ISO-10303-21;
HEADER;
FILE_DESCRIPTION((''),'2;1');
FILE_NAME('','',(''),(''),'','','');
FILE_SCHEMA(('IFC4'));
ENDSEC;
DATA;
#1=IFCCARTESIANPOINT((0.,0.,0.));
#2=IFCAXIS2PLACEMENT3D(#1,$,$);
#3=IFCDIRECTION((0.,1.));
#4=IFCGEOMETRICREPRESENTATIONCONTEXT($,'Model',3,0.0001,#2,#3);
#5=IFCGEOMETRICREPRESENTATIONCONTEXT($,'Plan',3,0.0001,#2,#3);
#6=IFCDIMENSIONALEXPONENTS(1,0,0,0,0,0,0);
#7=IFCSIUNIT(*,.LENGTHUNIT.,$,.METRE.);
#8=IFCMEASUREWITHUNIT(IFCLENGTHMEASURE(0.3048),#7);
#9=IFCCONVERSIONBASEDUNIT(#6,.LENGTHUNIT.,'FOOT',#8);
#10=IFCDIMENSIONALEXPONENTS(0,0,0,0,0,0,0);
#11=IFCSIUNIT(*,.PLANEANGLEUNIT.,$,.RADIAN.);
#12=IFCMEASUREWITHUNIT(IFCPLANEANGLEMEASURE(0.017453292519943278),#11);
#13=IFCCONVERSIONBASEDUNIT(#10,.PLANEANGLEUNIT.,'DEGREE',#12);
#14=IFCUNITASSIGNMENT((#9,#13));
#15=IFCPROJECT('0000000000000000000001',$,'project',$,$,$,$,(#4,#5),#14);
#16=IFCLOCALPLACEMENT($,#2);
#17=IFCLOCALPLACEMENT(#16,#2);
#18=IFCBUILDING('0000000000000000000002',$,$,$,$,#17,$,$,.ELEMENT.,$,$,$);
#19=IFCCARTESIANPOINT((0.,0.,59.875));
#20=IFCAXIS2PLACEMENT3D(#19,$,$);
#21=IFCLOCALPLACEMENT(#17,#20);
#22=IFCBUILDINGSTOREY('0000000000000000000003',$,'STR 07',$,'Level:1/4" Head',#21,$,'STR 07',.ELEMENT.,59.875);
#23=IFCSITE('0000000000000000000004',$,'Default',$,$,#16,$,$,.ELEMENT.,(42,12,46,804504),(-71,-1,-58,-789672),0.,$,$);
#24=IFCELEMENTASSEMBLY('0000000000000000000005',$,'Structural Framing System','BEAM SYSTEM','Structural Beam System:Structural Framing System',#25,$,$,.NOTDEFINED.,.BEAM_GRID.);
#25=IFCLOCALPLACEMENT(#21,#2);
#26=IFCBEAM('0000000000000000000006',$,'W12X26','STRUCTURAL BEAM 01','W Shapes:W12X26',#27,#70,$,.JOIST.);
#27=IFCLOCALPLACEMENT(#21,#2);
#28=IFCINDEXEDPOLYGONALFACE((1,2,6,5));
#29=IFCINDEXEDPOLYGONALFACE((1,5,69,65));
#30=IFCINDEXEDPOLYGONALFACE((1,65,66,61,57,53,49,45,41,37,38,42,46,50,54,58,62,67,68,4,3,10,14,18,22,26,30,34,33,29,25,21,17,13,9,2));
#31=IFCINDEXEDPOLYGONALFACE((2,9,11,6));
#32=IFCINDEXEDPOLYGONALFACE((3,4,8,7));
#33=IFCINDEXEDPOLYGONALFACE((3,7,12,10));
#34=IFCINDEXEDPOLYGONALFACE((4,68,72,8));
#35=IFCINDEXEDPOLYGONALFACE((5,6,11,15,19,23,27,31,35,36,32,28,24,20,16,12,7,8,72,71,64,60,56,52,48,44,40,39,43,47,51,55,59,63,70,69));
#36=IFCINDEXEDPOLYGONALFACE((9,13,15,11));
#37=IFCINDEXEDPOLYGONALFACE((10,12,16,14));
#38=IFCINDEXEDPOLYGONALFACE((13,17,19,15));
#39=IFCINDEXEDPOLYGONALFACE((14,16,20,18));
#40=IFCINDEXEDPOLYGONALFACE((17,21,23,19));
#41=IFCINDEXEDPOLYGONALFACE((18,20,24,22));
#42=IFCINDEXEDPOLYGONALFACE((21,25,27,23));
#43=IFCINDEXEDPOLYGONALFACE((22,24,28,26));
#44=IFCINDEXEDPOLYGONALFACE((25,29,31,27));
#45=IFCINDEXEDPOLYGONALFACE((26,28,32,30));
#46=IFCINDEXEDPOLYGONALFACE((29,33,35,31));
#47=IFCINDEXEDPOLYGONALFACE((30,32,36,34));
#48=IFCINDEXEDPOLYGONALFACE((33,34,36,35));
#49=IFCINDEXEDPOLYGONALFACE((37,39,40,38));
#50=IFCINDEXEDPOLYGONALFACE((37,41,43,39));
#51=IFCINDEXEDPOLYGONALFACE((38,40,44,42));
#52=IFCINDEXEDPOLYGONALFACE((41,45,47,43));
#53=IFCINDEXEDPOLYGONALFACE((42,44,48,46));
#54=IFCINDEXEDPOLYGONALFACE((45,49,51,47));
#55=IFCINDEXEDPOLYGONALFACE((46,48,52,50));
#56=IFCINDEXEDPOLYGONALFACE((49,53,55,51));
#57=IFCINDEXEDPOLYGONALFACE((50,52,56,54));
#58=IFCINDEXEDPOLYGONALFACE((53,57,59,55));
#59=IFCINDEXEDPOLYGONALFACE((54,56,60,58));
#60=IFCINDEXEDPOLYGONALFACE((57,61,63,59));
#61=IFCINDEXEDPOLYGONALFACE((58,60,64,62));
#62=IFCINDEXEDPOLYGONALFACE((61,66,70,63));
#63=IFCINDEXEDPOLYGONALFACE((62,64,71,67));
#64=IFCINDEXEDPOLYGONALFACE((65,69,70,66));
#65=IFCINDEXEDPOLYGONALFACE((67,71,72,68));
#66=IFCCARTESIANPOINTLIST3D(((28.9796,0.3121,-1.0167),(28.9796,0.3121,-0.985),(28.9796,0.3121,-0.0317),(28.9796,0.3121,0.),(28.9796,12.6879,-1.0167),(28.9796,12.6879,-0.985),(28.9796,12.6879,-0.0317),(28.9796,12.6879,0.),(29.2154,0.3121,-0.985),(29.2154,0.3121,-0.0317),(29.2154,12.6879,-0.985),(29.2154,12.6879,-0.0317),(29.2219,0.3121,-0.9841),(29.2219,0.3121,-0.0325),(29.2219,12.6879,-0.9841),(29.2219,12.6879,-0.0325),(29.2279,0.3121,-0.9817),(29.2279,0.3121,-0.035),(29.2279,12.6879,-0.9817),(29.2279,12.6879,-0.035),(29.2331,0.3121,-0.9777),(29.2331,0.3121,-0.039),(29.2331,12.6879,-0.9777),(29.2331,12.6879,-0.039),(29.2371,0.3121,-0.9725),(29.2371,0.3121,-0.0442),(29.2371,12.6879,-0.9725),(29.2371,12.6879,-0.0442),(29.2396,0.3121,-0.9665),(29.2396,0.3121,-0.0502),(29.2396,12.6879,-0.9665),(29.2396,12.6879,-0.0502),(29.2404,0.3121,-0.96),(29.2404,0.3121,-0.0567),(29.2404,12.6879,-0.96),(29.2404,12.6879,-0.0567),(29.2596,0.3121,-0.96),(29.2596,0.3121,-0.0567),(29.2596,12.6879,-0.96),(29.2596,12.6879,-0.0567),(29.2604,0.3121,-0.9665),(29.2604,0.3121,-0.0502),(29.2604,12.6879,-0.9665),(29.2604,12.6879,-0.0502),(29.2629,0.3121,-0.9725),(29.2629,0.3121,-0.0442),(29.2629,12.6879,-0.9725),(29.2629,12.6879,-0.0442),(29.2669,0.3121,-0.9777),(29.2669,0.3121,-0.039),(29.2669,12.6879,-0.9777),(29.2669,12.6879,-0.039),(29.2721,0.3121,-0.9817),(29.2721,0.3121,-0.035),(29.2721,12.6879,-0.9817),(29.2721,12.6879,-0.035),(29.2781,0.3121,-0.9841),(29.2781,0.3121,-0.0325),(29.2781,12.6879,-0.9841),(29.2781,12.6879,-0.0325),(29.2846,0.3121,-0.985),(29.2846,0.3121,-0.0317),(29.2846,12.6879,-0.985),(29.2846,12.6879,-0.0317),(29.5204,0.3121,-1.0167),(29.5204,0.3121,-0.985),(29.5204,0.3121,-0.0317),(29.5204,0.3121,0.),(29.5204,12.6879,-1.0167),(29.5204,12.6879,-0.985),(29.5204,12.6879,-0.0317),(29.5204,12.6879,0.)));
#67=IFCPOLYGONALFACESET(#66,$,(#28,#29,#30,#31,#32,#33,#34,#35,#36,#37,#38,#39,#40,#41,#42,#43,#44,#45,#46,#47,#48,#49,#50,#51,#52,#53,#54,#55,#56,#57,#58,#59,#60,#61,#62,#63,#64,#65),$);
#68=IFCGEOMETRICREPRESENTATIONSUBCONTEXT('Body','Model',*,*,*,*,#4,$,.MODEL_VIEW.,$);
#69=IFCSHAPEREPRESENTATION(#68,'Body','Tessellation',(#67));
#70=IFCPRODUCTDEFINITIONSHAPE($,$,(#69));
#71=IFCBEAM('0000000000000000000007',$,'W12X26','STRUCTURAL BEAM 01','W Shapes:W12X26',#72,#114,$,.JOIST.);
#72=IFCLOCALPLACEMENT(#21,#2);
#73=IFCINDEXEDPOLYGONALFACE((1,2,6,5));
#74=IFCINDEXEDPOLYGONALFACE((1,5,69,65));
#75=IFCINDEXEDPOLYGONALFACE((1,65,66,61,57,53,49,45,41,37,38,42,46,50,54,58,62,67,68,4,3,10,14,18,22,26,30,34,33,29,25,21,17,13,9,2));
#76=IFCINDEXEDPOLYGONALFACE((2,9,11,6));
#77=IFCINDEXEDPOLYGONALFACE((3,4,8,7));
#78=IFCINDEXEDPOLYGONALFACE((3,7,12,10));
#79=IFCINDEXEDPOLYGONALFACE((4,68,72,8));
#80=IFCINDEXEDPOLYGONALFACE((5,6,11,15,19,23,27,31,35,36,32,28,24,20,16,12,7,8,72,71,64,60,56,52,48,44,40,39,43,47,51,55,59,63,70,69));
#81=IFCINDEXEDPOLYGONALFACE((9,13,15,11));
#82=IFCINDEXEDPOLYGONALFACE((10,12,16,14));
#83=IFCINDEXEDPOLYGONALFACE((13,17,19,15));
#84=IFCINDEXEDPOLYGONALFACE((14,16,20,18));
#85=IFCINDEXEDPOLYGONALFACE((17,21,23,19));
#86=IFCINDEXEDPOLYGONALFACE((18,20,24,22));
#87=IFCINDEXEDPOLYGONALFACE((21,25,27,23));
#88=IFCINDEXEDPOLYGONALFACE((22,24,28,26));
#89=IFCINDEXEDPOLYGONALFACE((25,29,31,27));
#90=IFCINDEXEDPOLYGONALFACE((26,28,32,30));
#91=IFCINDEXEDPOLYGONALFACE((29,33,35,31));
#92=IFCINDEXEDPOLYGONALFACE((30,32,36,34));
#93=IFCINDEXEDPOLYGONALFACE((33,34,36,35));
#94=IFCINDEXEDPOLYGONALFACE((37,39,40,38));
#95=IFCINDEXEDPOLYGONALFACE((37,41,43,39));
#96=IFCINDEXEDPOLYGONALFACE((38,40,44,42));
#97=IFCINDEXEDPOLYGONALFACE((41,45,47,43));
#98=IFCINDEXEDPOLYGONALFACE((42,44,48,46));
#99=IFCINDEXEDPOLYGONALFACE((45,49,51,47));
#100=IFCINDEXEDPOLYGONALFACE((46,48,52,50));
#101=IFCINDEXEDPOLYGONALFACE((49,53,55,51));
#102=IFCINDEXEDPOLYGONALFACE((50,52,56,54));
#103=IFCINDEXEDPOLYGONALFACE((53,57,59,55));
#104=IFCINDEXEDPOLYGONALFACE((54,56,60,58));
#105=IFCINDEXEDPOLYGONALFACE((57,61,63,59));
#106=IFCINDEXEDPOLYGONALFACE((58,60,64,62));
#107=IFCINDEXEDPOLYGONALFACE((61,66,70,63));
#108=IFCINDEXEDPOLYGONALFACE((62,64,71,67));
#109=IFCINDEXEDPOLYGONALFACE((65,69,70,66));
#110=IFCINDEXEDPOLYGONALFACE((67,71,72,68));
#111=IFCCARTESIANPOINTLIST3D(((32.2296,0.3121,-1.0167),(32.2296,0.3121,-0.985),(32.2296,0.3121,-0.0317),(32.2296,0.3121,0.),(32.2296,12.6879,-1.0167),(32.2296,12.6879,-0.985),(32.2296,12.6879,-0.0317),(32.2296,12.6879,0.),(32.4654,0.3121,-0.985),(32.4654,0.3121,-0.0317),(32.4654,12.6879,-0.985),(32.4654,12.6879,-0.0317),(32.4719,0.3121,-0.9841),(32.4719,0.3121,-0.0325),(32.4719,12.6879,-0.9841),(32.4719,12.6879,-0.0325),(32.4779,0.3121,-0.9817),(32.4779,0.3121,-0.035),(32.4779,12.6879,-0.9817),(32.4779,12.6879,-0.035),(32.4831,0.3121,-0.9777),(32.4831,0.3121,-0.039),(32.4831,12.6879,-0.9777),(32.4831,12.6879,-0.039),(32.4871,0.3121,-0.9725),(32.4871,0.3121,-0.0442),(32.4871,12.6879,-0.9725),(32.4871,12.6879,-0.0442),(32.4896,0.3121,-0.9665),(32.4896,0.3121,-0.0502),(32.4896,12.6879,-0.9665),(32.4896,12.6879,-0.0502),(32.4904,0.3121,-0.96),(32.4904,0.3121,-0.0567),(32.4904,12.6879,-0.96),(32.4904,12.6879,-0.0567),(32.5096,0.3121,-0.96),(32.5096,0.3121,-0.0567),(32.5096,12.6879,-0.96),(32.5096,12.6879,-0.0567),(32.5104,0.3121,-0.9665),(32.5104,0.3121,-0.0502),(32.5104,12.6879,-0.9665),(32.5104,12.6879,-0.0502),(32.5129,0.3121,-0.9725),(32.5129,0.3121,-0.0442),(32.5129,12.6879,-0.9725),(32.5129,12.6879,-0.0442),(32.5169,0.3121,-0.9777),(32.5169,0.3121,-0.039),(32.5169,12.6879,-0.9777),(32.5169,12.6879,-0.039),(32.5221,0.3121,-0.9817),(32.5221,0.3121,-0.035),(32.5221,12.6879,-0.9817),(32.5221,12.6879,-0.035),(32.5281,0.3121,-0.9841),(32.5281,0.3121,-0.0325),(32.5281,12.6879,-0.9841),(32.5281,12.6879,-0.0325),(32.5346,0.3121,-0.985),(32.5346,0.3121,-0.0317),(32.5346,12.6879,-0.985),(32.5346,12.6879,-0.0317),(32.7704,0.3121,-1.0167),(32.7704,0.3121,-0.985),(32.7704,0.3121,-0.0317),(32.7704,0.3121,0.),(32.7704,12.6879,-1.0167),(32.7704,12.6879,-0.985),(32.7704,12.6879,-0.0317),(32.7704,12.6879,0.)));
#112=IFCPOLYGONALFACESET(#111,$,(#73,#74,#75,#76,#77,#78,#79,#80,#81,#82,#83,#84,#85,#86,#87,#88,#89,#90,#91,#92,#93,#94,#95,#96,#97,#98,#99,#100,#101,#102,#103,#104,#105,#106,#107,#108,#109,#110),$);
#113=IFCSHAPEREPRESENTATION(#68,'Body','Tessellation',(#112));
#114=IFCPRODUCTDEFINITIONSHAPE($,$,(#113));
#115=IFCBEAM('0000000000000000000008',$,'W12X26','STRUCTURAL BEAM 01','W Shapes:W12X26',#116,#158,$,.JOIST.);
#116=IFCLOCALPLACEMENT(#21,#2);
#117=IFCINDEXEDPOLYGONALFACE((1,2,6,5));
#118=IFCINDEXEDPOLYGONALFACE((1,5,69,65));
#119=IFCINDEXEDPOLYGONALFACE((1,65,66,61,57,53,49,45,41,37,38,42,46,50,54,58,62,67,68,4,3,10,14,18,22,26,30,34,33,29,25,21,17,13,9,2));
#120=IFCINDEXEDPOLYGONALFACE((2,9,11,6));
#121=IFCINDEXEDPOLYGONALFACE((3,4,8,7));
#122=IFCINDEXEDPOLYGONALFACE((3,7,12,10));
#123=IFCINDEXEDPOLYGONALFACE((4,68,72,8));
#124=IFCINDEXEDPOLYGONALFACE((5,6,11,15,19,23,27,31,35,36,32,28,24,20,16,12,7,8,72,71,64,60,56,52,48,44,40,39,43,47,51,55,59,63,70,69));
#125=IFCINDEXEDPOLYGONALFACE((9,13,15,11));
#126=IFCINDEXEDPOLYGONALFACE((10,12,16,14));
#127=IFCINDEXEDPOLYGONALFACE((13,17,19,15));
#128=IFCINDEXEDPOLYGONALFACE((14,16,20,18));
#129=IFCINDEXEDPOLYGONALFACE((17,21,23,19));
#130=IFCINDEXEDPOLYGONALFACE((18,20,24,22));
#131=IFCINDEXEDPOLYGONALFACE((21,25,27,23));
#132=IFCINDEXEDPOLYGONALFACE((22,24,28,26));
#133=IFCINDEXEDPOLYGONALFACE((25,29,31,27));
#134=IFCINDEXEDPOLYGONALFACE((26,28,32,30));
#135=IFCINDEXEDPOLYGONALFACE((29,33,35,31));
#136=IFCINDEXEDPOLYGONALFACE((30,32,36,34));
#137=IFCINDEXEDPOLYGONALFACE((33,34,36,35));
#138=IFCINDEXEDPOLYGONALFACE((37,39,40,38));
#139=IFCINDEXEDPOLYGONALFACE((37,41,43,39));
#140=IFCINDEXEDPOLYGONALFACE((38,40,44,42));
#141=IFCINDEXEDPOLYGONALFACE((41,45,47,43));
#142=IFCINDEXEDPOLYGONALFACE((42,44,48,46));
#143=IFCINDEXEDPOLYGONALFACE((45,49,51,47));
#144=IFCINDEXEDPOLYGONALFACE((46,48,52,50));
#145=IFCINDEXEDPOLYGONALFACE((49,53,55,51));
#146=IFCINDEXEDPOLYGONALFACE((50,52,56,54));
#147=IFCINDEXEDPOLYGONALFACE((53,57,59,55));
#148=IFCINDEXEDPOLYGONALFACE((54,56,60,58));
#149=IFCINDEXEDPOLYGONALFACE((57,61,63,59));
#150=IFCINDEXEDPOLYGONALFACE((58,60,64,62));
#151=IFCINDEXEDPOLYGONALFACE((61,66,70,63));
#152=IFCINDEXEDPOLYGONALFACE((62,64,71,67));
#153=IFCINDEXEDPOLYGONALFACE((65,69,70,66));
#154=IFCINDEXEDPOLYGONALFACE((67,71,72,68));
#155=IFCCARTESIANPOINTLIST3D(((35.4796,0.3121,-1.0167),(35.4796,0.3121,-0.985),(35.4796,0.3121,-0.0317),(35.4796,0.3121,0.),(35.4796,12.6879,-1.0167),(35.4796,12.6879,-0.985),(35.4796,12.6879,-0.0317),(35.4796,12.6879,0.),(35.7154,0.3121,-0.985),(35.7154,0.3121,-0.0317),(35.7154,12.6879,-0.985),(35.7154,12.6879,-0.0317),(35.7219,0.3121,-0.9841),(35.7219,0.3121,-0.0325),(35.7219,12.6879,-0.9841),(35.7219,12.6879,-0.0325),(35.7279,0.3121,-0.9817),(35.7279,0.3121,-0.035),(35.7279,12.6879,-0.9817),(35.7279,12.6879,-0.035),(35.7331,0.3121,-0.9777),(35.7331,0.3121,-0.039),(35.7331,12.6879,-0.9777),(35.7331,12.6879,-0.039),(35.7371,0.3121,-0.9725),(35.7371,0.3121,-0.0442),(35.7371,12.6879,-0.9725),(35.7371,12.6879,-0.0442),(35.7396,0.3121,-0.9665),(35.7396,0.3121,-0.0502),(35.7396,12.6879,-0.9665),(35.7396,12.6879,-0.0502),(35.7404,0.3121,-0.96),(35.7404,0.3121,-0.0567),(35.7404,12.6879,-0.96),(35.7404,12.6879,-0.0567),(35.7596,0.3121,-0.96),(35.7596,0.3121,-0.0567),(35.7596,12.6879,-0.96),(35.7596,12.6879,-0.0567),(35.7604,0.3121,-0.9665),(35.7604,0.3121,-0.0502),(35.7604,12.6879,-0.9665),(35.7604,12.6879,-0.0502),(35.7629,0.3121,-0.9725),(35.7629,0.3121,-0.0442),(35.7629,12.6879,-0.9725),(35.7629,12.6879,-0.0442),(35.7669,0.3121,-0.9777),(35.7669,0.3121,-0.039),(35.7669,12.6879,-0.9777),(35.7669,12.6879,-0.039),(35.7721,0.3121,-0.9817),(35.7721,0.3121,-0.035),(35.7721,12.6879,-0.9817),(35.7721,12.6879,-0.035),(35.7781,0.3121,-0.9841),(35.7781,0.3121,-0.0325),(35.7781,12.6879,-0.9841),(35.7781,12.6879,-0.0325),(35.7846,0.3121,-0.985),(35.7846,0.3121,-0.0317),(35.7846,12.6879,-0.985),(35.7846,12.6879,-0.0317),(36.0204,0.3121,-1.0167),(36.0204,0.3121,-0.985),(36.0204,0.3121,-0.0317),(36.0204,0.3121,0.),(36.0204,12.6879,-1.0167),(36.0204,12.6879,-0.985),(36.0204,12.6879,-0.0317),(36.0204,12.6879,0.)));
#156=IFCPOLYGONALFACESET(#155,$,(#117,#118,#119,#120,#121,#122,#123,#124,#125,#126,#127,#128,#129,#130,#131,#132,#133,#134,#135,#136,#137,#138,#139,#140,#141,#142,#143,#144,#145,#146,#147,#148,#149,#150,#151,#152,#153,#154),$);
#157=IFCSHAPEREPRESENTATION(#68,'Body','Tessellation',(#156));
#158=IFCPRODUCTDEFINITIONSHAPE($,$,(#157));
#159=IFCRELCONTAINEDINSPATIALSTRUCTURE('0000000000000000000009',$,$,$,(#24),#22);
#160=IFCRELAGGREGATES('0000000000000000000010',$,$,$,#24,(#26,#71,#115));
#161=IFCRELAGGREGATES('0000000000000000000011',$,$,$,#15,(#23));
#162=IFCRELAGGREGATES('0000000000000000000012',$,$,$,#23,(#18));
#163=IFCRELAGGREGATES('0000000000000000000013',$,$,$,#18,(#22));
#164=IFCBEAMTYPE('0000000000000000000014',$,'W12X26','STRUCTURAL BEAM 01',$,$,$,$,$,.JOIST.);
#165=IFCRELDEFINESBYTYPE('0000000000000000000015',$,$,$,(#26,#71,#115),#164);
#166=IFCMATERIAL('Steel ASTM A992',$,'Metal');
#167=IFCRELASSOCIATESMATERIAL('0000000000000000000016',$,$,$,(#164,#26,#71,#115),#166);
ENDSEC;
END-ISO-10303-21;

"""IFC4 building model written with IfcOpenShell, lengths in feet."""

from ifc_helpers import new_model, entity, si_unit, converted_unit, direction, frame, origin, place, context, subcontext, project, spatial, line, arc, indexed_curve, outline, extrude, source, transform, mapped, material, type_object, type_shapes, element, aggregate, save


model = new_model("IFC4")

# Units and contexts
model_context = context("Model", 3, precision=0.0001, world=origin(), true_north=direction((0.0, 1.0)))
plan_context = context("Plan", 3, precision=0.0001, world=origin(), true_north=direction((0.0, 1.0)))
body_context = subcontext(model_context, "Body", "Model", "MODEL_VIEW")
ifc_project = project(units=[converted_unit("LENGTHUNIT", "FOOT", entity("IfcLengthMeasure", 0.3048), si_unit("LENGTHUNIT", "METRE"), dimensions=[1, 0, 0, 0, 0, 0, 0]), converted_unit("PLANEANGLEUNIT", "DEGREE", entity("IfcPlaneAngleMeasure", 0.017453292519943278), si_unit("PLANEANGLEUNIT", "RADIAN"), dimensions=[0, 0, 0, 0, 0, 0, 0])], contexts=[model_context, plan_context])

# Site, building, storey
site_placement = place(None, origin())
site = spatial("IfcSite", under=ifc_project, at=site_placement, Name="Default", CompositionType="ELEMENT", RefLatitude=(42, 12, 46, 804504), RefLongitude=(-71, -1, -58, -789672), RefElevation=0.0)
building_placement = place(site_placement, origin())
building = spatial("IfcBuilding", under=site, at=building_placement, CompositionType="ELEMENT")
storey_placement = place(building_placement, frame((0.0, 0.0, 59.875)))
storey = spatial("IfcBuildingStorey", under=building, at=storey_placement, Name="STR 07", ObjectType="Level:1/4\" Head", LongName="STR 07", CompositionType="ELEMENT", Elevation=59.875)

# Element assembly, beams
ifc_material = material(Name="Steel ASTM A992", Category="Metal")
beam_type_1 = type_object("IfcBeamType", Name="W12X26", Description="STRUCTURAL BEAM 01", PredefinedType="JOIST", material=ifc_material)
shared_shape = source(origin(), body_context, "Body", "SweptSolid", [
    extrude(outline(indexed_curve([(-0.2704, -0.4767), (-0.2704, -0.5083), (0.2704, -0.5083), (0.2704, -0.4767), (0.0346, -0.4767), (0.0169, -0.4693), (0.0096, -0.4517), (0.0096, 0.4517), (0.0169, 0.4693), (0.0346, 0.4767), (0.2704, 0.4767), (0.2704, 0.5083), (-0.2704, 0.5083), (-0.2704, 0.4767), (-0.0346, 0.4767), (-0.0169, 0.4693), (-0.0096, 0.4517), (-0.0096, -0.4517), (-0.0169, -0.4693), (-0.0346, -0.4767)], segments=[line(1, 2, 3, 4, 5), arc(5, 6, 7), line(7, 8), arc(8, 9, 10), line(10, 11, 12, 13, 14, 15), arc(15, 16, 17), line(17, 18), arc(18, 19, 20), line(20, 1)], self_intersect=False)), frame((-6.1879, 0.0, 0.0), z_axis=(-1.0, 0.0, 0.0), x_axis=(0.0, -1.0, 0.0)), (0.0, 0.0, -1.0), 12.3758),
])
type_shapes(beam_type_1, [shared_shape])
assembly_1_placement = place(storey_placement, origin())
assembly_1 = element("IfcElementAssembly", 1, at=assembly_1_placement, inside=storey, Name="Structural Framing System", Description="BEAM SYSTEM", ObjectType="Structural Beam System:Structural Framing System", AssemblyPlace="NOTDEFINED", PredefinedType="BEAM_GRID")
beam_1_placement = place(assembly_1_placement, frame((29.25, 6.5, -0.5083), z_axis=(0.0, 0.0, 1.0), x_axis=(0.0, 1.0, 0.0)))
beam_1 = element("IfcBeam", 2, at=beam_1_placement, type_object=beam_type_1, material=ifc_material, Name="W12X26", Description="STRUCTURAL BEAM 01", ObjectType="W Shapes:W12X26", PredefinedType="JOIST", context=body_context, shape_type="MappedRepresentation", body=[
    mapped(shared_shape, transform((0.0, 0.0, 0.0), scale=1.0)),
])
beam_2_placement = place(assembly_1_placement, frame((32.5, 6.5, -0.5083), z_axis=(0.0, 0.0, 1.0), x_axis=(0.0, 1.0, 0.0)))
beam_2 = element("IfcBeam", 3, at=beam_2_placement, type_object=beam_type_1, material=ifc_material, Name="W12X26", Description="STRUCTURAL BEAM 01", ObjectType="W Shapes:W12X26", PredefinedType="JOIST", context=body_context, shape_type="MappedRepresentation", body=[
    mapped(shared_shape, transform((0.0, 0.0, 0.0), scale=1.0)),
])
beam_3_placement = place(assembly_1_placement, frame((35.75, 6.5, -0.5083), z_axis=(0.0, 0.0, 1.0), x_axis=(0.0, 1.0, 0.0)))
beam_3 = element("IfcBeam", 4, at=beam_3_placement, type_object=beam_type_1, material=ifc_material, Name="W12X26", Description="STRUCTURAL BEAM 01", ObjectType="W Shapes:W12X26", PredefinedType="JOIST", context=body_context, shape_type="MappedRepresentation", body=[
    mapped(shared_shape, transform((0.0, 0.0, 0.0), scale=1.0)),
])
aggregate(assembly_1, [beam_1, beam_2, beam_3])

save(model, "model.ifc")
